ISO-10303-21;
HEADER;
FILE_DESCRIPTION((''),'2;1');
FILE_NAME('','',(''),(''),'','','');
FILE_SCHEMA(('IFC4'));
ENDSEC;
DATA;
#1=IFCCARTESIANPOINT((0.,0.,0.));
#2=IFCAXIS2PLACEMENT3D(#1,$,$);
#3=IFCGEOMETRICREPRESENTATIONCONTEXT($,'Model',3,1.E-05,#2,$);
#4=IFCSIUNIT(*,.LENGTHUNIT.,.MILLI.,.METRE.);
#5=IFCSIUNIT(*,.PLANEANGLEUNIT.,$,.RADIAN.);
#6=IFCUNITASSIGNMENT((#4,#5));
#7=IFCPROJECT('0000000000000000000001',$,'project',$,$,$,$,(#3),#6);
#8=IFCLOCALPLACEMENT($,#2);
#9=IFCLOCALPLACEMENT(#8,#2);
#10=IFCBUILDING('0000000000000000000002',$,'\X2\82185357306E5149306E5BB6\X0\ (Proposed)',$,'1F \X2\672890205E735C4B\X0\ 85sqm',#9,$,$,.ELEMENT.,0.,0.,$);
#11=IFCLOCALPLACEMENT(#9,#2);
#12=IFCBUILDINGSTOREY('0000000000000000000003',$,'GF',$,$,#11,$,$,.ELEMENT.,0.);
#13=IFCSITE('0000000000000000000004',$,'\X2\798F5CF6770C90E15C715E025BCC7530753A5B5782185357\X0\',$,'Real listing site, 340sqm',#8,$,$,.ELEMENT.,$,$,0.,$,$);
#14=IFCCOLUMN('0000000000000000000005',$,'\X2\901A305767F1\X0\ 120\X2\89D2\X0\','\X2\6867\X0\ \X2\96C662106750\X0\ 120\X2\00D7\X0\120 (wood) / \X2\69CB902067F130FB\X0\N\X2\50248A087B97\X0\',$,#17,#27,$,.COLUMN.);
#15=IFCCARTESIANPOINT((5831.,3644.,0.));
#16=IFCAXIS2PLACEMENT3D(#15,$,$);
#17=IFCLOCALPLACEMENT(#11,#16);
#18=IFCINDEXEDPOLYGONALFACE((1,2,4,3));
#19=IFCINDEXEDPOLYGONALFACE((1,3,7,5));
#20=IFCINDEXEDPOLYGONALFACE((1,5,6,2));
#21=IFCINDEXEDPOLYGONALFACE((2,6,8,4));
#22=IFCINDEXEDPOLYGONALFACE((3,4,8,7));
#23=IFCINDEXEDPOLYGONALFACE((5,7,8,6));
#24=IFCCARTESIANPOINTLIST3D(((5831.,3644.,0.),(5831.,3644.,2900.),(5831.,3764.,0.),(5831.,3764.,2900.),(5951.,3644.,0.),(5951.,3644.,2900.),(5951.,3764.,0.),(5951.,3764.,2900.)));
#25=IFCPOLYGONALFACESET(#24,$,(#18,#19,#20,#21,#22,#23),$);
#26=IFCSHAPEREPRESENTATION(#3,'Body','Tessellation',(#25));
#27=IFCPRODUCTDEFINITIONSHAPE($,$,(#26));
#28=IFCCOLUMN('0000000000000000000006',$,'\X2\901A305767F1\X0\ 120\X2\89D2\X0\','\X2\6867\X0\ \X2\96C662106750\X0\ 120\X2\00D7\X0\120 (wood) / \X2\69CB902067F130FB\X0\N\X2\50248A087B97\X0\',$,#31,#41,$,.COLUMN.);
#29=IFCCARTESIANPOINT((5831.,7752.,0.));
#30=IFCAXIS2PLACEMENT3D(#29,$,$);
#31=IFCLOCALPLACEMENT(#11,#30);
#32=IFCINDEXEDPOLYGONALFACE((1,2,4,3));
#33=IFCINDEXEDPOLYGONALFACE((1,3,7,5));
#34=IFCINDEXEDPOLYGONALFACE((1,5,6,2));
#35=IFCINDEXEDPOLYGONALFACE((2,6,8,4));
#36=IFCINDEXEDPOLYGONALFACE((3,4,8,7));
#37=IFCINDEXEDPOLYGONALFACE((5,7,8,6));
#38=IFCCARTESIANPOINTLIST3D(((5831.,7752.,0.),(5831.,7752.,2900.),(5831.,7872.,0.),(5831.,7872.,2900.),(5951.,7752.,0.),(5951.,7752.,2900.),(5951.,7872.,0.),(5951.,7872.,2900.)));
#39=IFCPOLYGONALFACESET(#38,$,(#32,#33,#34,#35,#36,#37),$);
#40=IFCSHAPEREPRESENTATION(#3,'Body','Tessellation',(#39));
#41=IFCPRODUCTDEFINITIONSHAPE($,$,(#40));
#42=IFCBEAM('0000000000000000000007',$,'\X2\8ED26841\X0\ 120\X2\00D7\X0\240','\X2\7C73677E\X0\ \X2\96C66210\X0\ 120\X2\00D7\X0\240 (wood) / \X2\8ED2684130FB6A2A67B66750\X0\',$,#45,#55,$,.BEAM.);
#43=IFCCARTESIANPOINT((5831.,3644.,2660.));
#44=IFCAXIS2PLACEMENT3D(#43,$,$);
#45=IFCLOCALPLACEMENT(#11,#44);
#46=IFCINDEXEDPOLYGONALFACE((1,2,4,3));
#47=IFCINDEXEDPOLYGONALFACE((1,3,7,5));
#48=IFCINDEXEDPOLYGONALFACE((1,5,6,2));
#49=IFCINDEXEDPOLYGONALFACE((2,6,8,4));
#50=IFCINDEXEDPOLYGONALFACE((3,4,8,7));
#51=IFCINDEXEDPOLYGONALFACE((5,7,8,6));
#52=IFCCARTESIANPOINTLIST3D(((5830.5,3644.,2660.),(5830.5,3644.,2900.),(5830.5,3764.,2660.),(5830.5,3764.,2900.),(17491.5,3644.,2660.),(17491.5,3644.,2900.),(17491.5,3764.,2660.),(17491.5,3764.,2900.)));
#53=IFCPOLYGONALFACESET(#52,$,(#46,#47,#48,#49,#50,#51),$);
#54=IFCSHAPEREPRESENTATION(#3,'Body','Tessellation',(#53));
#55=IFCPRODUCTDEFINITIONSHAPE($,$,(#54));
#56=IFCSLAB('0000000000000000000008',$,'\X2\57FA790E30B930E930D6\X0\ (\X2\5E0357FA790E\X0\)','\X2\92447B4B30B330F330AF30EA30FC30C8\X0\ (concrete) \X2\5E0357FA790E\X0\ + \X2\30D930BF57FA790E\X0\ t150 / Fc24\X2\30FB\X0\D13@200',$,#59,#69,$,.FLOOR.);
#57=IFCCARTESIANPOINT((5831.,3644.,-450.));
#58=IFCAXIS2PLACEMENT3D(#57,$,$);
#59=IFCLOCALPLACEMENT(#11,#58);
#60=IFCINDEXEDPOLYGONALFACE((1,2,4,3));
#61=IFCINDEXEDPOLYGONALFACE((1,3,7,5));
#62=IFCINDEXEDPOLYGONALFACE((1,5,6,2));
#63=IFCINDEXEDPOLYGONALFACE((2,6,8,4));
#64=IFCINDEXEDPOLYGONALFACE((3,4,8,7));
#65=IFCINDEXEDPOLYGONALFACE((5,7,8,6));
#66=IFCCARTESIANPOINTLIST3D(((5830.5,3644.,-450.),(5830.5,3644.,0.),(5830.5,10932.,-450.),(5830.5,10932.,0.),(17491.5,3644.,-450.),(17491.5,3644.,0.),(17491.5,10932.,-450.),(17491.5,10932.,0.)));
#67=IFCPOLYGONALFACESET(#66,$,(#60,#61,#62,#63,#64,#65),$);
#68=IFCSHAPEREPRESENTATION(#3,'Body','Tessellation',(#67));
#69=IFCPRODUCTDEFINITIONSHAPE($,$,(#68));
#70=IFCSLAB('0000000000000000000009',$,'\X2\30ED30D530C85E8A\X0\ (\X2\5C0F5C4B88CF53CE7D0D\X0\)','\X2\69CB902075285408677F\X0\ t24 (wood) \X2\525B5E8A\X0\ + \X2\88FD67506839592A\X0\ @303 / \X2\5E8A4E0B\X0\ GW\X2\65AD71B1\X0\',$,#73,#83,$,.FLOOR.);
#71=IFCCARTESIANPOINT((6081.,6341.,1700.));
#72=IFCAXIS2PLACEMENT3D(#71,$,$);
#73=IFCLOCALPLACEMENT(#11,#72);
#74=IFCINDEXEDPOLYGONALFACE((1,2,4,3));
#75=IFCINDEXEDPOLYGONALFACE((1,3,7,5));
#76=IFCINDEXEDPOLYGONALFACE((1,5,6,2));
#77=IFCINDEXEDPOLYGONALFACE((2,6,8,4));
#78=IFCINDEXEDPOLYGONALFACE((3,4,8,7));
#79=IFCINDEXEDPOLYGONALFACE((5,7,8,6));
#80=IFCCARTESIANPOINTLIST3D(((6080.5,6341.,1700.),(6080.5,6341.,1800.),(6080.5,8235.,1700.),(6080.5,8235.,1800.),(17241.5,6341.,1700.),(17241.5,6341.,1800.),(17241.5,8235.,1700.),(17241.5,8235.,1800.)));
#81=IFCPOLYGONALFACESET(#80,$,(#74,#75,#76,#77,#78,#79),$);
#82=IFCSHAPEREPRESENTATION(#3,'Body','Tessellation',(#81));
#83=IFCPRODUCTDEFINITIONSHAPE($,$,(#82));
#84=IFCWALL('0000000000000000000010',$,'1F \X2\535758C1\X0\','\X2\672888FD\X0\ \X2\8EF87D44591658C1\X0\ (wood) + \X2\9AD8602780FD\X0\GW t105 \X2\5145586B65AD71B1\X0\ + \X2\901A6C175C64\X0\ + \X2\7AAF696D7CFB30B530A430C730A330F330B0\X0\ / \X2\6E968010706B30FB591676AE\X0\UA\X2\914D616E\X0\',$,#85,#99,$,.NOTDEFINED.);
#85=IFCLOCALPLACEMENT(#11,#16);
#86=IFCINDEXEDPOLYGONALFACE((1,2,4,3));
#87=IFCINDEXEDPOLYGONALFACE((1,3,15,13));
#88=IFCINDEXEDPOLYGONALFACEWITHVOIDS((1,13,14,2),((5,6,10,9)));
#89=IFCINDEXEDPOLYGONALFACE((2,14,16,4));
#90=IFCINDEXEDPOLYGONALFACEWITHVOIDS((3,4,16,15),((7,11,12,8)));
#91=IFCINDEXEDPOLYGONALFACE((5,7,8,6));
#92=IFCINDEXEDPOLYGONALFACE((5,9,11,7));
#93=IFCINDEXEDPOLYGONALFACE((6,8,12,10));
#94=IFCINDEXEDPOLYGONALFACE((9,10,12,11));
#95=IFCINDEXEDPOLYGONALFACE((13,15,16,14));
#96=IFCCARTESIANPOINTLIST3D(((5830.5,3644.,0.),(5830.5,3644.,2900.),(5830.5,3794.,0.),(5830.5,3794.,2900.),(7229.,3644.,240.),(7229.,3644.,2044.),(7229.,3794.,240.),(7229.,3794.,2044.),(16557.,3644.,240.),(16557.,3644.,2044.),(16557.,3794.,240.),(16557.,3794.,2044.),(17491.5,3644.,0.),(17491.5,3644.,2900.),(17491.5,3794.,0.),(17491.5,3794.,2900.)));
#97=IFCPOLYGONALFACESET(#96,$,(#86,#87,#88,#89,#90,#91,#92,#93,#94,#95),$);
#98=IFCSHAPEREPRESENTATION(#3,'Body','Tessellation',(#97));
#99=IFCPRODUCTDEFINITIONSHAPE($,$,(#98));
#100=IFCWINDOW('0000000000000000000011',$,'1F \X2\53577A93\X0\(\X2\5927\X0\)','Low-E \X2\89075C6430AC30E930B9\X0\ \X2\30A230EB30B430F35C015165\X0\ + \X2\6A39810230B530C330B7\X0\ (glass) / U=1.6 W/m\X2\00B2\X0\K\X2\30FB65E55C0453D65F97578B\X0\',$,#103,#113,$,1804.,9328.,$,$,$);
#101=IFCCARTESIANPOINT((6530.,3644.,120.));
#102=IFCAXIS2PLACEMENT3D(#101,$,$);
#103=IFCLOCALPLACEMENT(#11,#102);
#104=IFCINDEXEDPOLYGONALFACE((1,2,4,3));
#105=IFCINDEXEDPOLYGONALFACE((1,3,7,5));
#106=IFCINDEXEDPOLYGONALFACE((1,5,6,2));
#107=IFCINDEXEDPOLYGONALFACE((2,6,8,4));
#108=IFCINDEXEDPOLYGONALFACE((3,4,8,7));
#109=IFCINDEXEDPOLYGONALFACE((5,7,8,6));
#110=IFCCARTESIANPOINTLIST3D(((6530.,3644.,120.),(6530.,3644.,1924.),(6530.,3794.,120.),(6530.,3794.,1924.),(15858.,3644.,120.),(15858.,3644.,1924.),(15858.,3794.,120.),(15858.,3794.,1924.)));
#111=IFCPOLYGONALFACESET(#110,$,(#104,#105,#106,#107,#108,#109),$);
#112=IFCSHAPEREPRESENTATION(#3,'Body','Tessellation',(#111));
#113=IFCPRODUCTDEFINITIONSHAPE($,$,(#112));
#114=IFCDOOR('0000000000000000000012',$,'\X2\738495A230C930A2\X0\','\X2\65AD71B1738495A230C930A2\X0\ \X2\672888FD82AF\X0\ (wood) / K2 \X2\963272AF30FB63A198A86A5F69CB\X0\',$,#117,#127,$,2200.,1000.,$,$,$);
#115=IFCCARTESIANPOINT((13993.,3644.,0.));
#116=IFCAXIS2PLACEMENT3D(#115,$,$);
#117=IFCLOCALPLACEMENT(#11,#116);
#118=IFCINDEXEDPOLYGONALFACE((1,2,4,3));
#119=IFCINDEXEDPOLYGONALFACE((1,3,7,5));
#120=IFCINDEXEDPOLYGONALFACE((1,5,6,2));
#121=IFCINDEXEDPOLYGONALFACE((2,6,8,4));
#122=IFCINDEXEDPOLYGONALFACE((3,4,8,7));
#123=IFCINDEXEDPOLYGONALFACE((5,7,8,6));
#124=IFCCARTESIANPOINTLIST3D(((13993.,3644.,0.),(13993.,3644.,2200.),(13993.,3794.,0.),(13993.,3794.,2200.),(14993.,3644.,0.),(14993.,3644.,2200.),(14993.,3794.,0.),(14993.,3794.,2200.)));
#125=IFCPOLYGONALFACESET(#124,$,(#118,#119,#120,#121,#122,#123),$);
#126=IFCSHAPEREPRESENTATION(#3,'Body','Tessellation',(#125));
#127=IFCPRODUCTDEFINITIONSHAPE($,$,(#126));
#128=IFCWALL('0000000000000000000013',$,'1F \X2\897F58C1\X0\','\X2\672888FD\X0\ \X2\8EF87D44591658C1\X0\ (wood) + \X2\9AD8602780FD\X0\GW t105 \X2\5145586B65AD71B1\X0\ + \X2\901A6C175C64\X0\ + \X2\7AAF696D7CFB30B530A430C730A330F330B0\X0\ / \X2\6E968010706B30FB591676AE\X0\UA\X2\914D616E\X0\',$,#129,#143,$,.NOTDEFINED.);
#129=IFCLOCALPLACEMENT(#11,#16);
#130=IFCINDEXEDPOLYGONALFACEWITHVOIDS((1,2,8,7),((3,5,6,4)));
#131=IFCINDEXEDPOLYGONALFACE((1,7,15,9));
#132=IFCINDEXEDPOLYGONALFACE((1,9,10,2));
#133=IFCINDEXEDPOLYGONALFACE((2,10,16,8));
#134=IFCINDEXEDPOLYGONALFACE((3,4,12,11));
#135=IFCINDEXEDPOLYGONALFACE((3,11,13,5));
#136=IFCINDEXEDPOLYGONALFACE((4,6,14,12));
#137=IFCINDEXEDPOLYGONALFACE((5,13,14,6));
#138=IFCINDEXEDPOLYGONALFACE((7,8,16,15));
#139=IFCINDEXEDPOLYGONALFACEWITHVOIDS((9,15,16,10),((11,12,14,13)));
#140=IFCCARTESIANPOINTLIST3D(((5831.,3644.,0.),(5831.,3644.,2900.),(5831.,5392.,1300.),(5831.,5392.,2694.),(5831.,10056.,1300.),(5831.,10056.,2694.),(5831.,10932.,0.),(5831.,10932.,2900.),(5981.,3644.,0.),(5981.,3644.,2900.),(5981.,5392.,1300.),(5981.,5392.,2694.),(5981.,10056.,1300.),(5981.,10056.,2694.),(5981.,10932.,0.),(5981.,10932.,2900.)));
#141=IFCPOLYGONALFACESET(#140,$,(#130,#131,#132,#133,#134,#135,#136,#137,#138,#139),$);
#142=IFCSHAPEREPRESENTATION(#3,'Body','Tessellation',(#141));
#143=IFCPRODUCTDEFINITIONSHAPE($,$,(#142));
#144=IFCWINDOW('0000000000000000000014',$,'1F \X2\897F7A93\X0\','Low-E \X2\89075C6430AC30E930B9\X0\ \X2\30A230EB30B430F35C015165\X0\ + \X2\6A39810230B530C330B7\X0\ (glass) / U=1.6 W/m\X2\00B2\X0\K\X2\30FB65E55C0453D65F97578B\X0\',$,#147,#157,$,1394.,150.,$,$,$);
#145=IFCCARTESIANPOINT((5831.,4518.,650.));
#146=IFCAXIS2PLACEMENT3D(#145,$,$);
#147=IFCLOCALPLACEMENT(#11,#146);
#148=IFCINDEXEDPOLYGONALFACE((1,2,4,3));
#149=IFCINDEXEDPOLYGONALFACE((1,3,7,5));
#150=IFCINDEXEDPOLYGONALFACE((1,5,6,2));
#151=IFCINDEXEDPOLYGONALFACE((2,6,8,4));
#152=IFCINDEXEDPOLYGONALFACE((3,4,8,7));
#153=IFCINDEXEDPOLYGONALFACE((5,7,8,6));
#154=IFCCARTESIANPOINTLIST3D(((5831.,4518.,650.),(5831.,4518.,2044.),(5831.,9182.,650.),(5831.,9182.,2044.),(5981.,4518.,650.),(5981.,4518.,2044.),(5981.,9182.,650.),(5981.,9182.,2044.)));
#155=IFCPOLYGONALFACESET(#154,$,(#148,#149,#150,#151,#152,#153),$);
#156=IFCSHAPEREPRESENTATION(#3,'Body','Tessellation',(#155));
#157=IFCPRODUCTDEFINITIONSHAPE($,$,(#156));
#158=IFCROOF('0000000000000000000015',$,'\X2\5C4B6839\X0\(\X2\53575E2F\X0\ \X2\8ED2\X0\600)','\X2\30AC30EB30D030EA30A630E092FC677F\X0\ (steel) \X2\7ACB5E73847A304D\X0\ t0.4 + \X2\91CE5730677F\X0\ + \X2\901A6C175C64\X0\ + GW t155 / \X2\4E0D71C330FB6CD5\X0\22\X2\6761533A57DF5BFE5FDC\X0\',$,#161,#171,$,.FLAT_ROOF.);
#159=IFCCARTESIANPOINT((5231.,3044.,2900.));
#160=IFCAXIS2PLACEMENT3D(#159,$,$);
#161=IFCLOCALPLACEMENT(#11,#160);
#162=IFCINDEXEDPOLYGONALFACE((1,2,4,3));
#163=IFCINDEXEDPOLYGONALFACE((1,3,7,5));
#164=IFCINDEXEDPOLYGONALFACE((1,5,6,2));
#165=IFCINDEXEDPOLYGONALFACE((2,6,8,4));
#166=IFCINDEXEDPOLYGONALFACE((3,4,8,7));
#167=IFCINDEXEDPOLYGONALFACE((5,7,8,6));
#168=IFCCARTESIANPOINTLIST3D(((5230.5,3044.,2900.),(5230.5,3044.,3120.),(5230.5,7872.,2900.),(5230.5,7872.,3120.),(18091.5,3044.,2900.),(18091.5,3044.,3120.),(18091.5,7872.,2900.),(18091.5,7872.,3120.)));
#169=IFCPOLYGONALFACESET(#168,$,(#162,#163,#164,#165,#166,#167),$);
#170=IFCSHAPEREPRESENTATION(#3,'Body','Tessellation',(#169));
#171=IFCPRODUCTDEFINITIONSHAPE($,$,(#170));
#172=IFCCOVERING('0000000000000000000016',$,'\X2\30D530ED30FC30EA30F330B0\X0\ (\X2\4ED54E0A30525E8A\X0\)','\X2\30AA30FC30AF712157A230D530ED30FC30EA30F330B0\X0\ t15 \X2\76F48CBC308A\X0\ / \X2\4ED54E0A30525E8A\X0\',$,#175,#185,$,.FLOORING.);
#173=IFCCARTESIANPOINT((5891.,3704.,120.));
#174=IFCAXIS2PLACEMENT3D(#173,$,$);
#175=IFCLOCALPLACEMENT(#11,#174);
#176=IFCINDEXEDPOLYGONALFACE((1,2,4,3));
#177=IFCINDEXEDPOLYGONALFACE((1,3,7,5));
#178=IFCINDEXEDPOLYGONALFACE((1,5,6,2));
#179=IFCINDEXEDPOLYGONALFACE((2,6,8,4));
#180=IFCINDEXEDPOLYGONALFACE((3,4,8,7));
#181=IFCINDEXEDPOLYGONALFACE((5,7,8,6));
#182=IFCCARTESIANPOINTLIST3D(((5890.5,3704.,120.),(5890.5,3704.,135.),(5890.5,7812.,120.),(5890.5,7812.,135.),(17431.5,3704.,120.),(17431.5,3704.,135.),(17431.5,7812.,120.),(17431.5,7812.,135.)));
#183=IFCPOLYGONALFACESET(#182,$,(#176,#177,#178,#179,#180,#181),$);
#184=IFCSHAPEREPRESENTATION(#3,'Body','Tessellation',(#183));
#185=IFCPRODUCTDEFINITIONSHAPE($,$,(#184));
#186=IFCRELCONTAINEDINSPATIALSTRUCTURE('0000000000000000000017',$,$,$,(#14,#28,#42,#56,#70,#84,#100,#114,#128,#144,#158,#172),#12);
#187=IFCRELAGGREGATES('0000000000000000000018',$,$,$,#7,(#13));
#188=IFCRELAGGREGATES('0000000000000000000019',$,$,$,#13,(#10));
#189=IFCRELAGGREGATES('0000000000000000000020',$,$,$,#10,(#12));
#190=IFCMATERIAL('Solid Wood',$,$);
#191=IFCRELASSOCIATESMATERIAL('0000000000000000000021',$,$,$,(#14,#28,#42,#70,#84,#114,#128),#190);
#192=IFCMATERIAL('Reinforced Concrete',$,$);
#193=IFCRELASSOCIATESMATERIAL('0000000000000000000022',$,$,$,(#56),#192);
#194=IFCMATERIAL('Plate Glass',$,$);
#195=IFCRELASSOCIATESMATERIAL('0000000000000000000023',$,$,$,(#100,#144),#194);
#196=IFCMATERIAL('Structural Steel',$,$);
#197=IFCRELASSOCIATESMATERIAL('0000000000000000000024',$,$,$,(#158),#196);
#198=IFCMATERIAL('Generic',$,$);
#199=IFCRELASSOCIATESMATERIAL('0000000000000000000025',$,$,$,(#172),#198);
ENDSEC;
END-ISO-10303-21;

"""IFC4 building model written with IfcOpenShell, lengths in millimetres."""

from ifc_helpers import new_model, si_unit, frame, frame_2d, origin, place, context, project, spatial, rectangle, extrude, material, element, fill, save


model = new_model("IFC4")

# Units and contexts
model_context = context("Model", 3, precision=1e-05, world=origin())
ifc_project = project(units=[si_unit("LENGTHUNIT", "METRE", prefix="MILLI"), si_unit("PLANEANGLEUNIT", "RADIAN")], contexts=[model_context])

# Site, building, storey
site_placement = place(None, origin())
site = spatial("IfcSite", under=ifc_project, at=site_placement, Name="福島県郡山市富田町字舘南", ObjectType="Real listing site, 340sqm", CompositionType="ELEMENT", RefElevation=0.0)
building_placement = place(site_placement, origin())
building = spatial("IfcBuilding", under=site, at=building_placement, Name="舘南の光の家 (Proposed)", ObjectType="1F 木造平屋 85sqm", CompositionType="ELEMENT", ElevationOfRefHeight=0.0, ElevationOfTerrain=0.0)
storey_placement = place(building_placement, origin())
storey = spatial("IfcBuildingStorey", under=building, at=storey_placement, Name="GF", CompositionType="ELEMENT", Elevation=0.0)

# Columns
ifc_material_1 = material(Name="Solid Wood")
column_1_placement = place(storey_placement, frame((5831.0, 3644.0, 0.0)))
element("IfcColumn", 1, at=column_1_placement, inside=storey, material=ifc_material_1, Name="通し柱 120角", Description="桧 集成材 120×120 (wood) / 構造柱・N値計算", PredefinedType="COLUMN", context=model_context, shape_type="SweptSolid", body=[
    extrude(rectangle(XDim=120.0, YDim=120.0, at=frame_2d((60.0, 60.0))), frame((5831.0, 3644.0, 0.0)), (0.0, 0.0, 1.0), 2900.0),
])
column_2_placement = place(storey_placement, frame((5831.0, 7752.0, 0.0)))
element("IfcColumn", 2, at=column_2_placement, inside=storey, material=ifc_material_1, Name="通し柱 120角", Description="桧 集成材 120×120 (wood) / 構造柱・N値計算", PredefinedType="COLUMN", context=model_context, shape_type="SweptSolid", body=[
    extrude(rectangle(XDim=120.0, YDim=120.0, at=frame_2d((60.0, 60.0))), frame((5831.0, 7752.0, 0.0)), (0.0, 0.0, 1.0), 2900.0),
])

# Beam
beam_1_placement = place(storey_placement, frame((5831.0, 3644.0, 2660.0)))
element("IfcBeam", 3, at=beam_1_placement, inside=storey, material=ifc_material_1, Name="軒桁 120×240", Description="米松 集成 120×240 (wood) / 軒桁・横架材", PredefinedType="BEAM", context=model_context, shape_type="SweptSolid", body=[
    extrude(rectangle(XDim=11661.0, YDim=120.0, at=frame_2d((5830.0, 60.0))), frame((5831.0, 3644.0, 2660.0)), (0.0, 0.0, 1.0), 240.0),
])

# Slabs
ifc_material_2 = material(Name="Reinforced Concrete")
slab_1_placement = place(storey_placement, frame((5831.0, 3644.0, -450.0)))
element("IfcSlab", 4, at=slab_1_placement, inside=storey, material=ifc_material_2, Name="基礎スラブ (布基礎)", Description="鉄筋コンクリート (concrete) 布基礎 + ベタ基礎 t150 / Fc24・D13@200", PredefinedType="FLOOR", context=model_context, shape_type="SweptSolid", body=[
    extrude(rectangle(XDim=11661.0, YDim=7288.0, at=frame_2d((5830.0, 3644.0))), frame((5831.0, 3644.0, -450.0)), (0.0, 0.0, 1.0), 450.0),
])
slab_2_placement = place(storey_placement, frame((6081.0, 6341.0, 1700.0)))
element("IfcSlab", 5, at=slab_2_placement, inside=storey, material=ifc_material_1, Name="ロフト床 (小屋裏収納)", Description="構造用合板 t24 (wood) 剛床 + 製材根太 @303 / 床下 GW断熱", PredefinedType="FLOOR", context=model_context, shape_type="SweptSolid", body=[
    extrude(rectangle(XDim=11161.0, YDim=1894.0, at=frame_2d((5580.0, 947.0))), frame((6081.0, 6341.0, 1700.0)), (0.0, 0.0, 1.0), 100.0),
])

# Wall, openings, window, door
wall_1_placement = place(storey_placement, frame((5831.0, 3644.0, 0.0)))
wall_1 = element("IfcWall", 6, at=wall_1_placement, inside=storey, material=ifc_material_1, Name="1F 南壁", Description="木製 軸組外壁 (wood) + 高性能GW t105 充填断熱 + 通気層 + 窯業系サイディング / 準耐火・外皮UA配慮", PredefinedType="NOTDEFINED", context=model_context, shape_type="SweptSolid", body=[
    extrude(rectangle(XDim=11661.0, YDim=150.0, at=frame_2d((5830.0, 75.0))), frame((5831.0, 3644.0, 0.0)), (0.0, 0.0, 1.0), 2900.0),
])
opening_1_placement = place(storey_placement, frame((6530.0, 3644.0, 120.0)))
opening_1 = element("IfcOpeningElement", 7, at=opening_1_placement, cuts=wall_1, PredefinedType="NOTDEFINED", context=model_context, shape_type="SweptSolid", body=[
    extrude(rectangle(XDim=9328.0, YDim=150.0, at=frame_2d((4664.0, 75.0))), frame((6530.0, 3644.0, 120.0)), (0.0, 0.0, 1.0), 1804.0),
])
opening_2_placement = place(storey_placement, frame((13993.0, 3644.0, 0.0)))
opening_2 = element("IfcOpeningElement", 8, at=opening_2_placement, cuts=wall_1, PredefinedType="NOTDEFINED", context=model_context, shape_type="SweptSolid", body=[
    extrude(rectangle(XDim=1000.0, YDim=150.0, at=frame_2d((500.0, 75.0))), frame((13993.0, 3644.0, 0.0)), (0.0, 0.0, 1.0), 2200.0),
])
ifc_material_3 = material(Name="Plate Glass")
window_1_placement = place(storey_placement, frame((6530.0, 3644.0, 120.0)))
window_1 = element("IfcWindow", 9, at=window_1_placement, inside=storey, material=ifc_material_3, Name="1F 南窓(大)", Description="Low-E 複層ガラス アルゴン封入 + 樹脂サッシ (glass) / U=1.6 W/m²K・日射取得型", OverallHeight=1804.0, OverallWidth=9328.0, context=model_context, shape_type="SweptSolid", body=[
    extrude(rectangle(XDim=9328.0, YDim=150.0, at=frame_2d((4664.0, 75.0))), frame((6530.0, 3644.0, 120.0)), (0.0, 0.0, 1.0), 1804.0),
])
fill(opening_1, window_1)
door_placement = place(storey_placement, frame((13993.0, 3644.0, 0.0)))
door = element("IfcDoor", 10, at=door_placement, inside=storey, material=ifc_material_1, Name="玄関ドア", Description="断熱玄関ドア 木製芯 (wood) / K2 防犯・採風機構", OverallHeight=2200.0, OverallWidth=1000.0, context=model_context, shape_type="SweptSolid", body=[
    extrude(rectangle(XDim=1000.0, YDim=150.0, at=frame_2d((500.0, 75.0))), frame((13993.0, 3644.0, 0.0)), (0.0, 0.0, 1.0), 2200.0),
])
fill(opening_2, door)

# Wall, opening, window
wall_2_placement = place(storey_placement, frame((5831.0, 3644.0, 0.0)))
wall_2 = element("IfcWall", 11, at=wall_2_placement, inside=storey, material=ifc_material_1, Name="1F 西壁", Description="木製 軸組外壁 (wood) + 高性能GW t105 充填断熱 + 通気層 + 窯業系サイディング / 準耐火・外皮UA配慮", PredefinedType="NOTDEFINED", context=model_context, shape_type="SweptSolid", body=[
    extrude(rectangle(XDim=150.0, YDim=7288.0, at=frame_2d((75.0, 3644.0))), frame((5831.0, 3644.0, 0.0)), (0.0, 0.0, 1.0), 2900.0),
])
opening_3_placement = place(storey_placement, frame((5831.0, 4518.0, 650.0)))
opening_3 = element("IfcOpeningElement", 12, at=opening_3_placement, cuts=wall_2, PredefinedType="NOTDEFINED", context=model_context, shape_type="SweptSolid", body=[
    extrude(rectangle(XDim=150.0, YDim=4664.0, at=frame_2d((75.0, 2332.0))), frame((5831.0, 4518.0, 650.0)), (0.0, 0.0, 1.0), 1394.0),
])
window_2_placement = place(storey_placement, frame((5831.0, 4518.0, 650.0)))
window_2 = element("IfcWindow", 13, at=window_2_placement, inside=storey, material=ifc_material_3, Name="1F 西窓", Description="Low-E 複層ガラス アルゴン封入 + 樹脂サッシ (glass) / U=1.6 W/m²K・日射取得型", OverallHeight=1394.0, OverallWidth=150.0, context=model_context, shape_type="SweptSolid", body=[
    extrude(rectangle(XDim=150.0, YDim=4664.0, at=frame_2d((75.0, 2332.0))), frame((5831.0, 4518.0, 650.0)), (0.0, 0.0, 1.0), 1394.0),
])
fill(opening_3, window_2)

# Roof
ifc_material_4 = material(Name="Structural Steel")
roof_placement = place(storey_placement, frame((5231.0, 3044.0, 2900.0)))
element("IfcRoof", 14, at=roof_placement, inside=storey, material=ifc_material_4, Name="屋根(南帯 軒600)", Description="ガルバリウム鋼板 (steel) 立平葺き t0.4 + 野地板 + 通気層 + GW t155 / 不燃・法22条区域対応", PredefinedType="FLAT_ROOF", context=model_context, shape_type="SweptSolid", body=[
    extrude(rectangle(XDim=12861.0, YDim=4828.0, at=frame_2d((6430.0, 2414.0))), frame((5231.0, 3044.0, 2900.0)), (0.0, 0.0, 1.0), 220.0),
])

# Covering
ifc_material_5 = material(Name="Generic")
covering_1_placement = place(storey_placement, frame((5891.0, 3704.0, 120.0)))
element("IfcCovering", 15, at=covering_1_placement, inside=storey, material=ifc_material_5, Name="フローリング (仕上げ床)", Description="オーク無垢フローリング t15 直貼り / 仕上げ床", PredefinedType="FLOORING", context=model_context, shape_type="SweptSolid", body=[
    extrude(rectangle(XDim=11541.0, YDim=4108.0, at=frame_2d((5770.0, 2054.0))), frame((5891.0, 3704.0, 120.0)), (0.0, 0.0, 1.0), 15.0),
])

save(model, "model.ifc")
